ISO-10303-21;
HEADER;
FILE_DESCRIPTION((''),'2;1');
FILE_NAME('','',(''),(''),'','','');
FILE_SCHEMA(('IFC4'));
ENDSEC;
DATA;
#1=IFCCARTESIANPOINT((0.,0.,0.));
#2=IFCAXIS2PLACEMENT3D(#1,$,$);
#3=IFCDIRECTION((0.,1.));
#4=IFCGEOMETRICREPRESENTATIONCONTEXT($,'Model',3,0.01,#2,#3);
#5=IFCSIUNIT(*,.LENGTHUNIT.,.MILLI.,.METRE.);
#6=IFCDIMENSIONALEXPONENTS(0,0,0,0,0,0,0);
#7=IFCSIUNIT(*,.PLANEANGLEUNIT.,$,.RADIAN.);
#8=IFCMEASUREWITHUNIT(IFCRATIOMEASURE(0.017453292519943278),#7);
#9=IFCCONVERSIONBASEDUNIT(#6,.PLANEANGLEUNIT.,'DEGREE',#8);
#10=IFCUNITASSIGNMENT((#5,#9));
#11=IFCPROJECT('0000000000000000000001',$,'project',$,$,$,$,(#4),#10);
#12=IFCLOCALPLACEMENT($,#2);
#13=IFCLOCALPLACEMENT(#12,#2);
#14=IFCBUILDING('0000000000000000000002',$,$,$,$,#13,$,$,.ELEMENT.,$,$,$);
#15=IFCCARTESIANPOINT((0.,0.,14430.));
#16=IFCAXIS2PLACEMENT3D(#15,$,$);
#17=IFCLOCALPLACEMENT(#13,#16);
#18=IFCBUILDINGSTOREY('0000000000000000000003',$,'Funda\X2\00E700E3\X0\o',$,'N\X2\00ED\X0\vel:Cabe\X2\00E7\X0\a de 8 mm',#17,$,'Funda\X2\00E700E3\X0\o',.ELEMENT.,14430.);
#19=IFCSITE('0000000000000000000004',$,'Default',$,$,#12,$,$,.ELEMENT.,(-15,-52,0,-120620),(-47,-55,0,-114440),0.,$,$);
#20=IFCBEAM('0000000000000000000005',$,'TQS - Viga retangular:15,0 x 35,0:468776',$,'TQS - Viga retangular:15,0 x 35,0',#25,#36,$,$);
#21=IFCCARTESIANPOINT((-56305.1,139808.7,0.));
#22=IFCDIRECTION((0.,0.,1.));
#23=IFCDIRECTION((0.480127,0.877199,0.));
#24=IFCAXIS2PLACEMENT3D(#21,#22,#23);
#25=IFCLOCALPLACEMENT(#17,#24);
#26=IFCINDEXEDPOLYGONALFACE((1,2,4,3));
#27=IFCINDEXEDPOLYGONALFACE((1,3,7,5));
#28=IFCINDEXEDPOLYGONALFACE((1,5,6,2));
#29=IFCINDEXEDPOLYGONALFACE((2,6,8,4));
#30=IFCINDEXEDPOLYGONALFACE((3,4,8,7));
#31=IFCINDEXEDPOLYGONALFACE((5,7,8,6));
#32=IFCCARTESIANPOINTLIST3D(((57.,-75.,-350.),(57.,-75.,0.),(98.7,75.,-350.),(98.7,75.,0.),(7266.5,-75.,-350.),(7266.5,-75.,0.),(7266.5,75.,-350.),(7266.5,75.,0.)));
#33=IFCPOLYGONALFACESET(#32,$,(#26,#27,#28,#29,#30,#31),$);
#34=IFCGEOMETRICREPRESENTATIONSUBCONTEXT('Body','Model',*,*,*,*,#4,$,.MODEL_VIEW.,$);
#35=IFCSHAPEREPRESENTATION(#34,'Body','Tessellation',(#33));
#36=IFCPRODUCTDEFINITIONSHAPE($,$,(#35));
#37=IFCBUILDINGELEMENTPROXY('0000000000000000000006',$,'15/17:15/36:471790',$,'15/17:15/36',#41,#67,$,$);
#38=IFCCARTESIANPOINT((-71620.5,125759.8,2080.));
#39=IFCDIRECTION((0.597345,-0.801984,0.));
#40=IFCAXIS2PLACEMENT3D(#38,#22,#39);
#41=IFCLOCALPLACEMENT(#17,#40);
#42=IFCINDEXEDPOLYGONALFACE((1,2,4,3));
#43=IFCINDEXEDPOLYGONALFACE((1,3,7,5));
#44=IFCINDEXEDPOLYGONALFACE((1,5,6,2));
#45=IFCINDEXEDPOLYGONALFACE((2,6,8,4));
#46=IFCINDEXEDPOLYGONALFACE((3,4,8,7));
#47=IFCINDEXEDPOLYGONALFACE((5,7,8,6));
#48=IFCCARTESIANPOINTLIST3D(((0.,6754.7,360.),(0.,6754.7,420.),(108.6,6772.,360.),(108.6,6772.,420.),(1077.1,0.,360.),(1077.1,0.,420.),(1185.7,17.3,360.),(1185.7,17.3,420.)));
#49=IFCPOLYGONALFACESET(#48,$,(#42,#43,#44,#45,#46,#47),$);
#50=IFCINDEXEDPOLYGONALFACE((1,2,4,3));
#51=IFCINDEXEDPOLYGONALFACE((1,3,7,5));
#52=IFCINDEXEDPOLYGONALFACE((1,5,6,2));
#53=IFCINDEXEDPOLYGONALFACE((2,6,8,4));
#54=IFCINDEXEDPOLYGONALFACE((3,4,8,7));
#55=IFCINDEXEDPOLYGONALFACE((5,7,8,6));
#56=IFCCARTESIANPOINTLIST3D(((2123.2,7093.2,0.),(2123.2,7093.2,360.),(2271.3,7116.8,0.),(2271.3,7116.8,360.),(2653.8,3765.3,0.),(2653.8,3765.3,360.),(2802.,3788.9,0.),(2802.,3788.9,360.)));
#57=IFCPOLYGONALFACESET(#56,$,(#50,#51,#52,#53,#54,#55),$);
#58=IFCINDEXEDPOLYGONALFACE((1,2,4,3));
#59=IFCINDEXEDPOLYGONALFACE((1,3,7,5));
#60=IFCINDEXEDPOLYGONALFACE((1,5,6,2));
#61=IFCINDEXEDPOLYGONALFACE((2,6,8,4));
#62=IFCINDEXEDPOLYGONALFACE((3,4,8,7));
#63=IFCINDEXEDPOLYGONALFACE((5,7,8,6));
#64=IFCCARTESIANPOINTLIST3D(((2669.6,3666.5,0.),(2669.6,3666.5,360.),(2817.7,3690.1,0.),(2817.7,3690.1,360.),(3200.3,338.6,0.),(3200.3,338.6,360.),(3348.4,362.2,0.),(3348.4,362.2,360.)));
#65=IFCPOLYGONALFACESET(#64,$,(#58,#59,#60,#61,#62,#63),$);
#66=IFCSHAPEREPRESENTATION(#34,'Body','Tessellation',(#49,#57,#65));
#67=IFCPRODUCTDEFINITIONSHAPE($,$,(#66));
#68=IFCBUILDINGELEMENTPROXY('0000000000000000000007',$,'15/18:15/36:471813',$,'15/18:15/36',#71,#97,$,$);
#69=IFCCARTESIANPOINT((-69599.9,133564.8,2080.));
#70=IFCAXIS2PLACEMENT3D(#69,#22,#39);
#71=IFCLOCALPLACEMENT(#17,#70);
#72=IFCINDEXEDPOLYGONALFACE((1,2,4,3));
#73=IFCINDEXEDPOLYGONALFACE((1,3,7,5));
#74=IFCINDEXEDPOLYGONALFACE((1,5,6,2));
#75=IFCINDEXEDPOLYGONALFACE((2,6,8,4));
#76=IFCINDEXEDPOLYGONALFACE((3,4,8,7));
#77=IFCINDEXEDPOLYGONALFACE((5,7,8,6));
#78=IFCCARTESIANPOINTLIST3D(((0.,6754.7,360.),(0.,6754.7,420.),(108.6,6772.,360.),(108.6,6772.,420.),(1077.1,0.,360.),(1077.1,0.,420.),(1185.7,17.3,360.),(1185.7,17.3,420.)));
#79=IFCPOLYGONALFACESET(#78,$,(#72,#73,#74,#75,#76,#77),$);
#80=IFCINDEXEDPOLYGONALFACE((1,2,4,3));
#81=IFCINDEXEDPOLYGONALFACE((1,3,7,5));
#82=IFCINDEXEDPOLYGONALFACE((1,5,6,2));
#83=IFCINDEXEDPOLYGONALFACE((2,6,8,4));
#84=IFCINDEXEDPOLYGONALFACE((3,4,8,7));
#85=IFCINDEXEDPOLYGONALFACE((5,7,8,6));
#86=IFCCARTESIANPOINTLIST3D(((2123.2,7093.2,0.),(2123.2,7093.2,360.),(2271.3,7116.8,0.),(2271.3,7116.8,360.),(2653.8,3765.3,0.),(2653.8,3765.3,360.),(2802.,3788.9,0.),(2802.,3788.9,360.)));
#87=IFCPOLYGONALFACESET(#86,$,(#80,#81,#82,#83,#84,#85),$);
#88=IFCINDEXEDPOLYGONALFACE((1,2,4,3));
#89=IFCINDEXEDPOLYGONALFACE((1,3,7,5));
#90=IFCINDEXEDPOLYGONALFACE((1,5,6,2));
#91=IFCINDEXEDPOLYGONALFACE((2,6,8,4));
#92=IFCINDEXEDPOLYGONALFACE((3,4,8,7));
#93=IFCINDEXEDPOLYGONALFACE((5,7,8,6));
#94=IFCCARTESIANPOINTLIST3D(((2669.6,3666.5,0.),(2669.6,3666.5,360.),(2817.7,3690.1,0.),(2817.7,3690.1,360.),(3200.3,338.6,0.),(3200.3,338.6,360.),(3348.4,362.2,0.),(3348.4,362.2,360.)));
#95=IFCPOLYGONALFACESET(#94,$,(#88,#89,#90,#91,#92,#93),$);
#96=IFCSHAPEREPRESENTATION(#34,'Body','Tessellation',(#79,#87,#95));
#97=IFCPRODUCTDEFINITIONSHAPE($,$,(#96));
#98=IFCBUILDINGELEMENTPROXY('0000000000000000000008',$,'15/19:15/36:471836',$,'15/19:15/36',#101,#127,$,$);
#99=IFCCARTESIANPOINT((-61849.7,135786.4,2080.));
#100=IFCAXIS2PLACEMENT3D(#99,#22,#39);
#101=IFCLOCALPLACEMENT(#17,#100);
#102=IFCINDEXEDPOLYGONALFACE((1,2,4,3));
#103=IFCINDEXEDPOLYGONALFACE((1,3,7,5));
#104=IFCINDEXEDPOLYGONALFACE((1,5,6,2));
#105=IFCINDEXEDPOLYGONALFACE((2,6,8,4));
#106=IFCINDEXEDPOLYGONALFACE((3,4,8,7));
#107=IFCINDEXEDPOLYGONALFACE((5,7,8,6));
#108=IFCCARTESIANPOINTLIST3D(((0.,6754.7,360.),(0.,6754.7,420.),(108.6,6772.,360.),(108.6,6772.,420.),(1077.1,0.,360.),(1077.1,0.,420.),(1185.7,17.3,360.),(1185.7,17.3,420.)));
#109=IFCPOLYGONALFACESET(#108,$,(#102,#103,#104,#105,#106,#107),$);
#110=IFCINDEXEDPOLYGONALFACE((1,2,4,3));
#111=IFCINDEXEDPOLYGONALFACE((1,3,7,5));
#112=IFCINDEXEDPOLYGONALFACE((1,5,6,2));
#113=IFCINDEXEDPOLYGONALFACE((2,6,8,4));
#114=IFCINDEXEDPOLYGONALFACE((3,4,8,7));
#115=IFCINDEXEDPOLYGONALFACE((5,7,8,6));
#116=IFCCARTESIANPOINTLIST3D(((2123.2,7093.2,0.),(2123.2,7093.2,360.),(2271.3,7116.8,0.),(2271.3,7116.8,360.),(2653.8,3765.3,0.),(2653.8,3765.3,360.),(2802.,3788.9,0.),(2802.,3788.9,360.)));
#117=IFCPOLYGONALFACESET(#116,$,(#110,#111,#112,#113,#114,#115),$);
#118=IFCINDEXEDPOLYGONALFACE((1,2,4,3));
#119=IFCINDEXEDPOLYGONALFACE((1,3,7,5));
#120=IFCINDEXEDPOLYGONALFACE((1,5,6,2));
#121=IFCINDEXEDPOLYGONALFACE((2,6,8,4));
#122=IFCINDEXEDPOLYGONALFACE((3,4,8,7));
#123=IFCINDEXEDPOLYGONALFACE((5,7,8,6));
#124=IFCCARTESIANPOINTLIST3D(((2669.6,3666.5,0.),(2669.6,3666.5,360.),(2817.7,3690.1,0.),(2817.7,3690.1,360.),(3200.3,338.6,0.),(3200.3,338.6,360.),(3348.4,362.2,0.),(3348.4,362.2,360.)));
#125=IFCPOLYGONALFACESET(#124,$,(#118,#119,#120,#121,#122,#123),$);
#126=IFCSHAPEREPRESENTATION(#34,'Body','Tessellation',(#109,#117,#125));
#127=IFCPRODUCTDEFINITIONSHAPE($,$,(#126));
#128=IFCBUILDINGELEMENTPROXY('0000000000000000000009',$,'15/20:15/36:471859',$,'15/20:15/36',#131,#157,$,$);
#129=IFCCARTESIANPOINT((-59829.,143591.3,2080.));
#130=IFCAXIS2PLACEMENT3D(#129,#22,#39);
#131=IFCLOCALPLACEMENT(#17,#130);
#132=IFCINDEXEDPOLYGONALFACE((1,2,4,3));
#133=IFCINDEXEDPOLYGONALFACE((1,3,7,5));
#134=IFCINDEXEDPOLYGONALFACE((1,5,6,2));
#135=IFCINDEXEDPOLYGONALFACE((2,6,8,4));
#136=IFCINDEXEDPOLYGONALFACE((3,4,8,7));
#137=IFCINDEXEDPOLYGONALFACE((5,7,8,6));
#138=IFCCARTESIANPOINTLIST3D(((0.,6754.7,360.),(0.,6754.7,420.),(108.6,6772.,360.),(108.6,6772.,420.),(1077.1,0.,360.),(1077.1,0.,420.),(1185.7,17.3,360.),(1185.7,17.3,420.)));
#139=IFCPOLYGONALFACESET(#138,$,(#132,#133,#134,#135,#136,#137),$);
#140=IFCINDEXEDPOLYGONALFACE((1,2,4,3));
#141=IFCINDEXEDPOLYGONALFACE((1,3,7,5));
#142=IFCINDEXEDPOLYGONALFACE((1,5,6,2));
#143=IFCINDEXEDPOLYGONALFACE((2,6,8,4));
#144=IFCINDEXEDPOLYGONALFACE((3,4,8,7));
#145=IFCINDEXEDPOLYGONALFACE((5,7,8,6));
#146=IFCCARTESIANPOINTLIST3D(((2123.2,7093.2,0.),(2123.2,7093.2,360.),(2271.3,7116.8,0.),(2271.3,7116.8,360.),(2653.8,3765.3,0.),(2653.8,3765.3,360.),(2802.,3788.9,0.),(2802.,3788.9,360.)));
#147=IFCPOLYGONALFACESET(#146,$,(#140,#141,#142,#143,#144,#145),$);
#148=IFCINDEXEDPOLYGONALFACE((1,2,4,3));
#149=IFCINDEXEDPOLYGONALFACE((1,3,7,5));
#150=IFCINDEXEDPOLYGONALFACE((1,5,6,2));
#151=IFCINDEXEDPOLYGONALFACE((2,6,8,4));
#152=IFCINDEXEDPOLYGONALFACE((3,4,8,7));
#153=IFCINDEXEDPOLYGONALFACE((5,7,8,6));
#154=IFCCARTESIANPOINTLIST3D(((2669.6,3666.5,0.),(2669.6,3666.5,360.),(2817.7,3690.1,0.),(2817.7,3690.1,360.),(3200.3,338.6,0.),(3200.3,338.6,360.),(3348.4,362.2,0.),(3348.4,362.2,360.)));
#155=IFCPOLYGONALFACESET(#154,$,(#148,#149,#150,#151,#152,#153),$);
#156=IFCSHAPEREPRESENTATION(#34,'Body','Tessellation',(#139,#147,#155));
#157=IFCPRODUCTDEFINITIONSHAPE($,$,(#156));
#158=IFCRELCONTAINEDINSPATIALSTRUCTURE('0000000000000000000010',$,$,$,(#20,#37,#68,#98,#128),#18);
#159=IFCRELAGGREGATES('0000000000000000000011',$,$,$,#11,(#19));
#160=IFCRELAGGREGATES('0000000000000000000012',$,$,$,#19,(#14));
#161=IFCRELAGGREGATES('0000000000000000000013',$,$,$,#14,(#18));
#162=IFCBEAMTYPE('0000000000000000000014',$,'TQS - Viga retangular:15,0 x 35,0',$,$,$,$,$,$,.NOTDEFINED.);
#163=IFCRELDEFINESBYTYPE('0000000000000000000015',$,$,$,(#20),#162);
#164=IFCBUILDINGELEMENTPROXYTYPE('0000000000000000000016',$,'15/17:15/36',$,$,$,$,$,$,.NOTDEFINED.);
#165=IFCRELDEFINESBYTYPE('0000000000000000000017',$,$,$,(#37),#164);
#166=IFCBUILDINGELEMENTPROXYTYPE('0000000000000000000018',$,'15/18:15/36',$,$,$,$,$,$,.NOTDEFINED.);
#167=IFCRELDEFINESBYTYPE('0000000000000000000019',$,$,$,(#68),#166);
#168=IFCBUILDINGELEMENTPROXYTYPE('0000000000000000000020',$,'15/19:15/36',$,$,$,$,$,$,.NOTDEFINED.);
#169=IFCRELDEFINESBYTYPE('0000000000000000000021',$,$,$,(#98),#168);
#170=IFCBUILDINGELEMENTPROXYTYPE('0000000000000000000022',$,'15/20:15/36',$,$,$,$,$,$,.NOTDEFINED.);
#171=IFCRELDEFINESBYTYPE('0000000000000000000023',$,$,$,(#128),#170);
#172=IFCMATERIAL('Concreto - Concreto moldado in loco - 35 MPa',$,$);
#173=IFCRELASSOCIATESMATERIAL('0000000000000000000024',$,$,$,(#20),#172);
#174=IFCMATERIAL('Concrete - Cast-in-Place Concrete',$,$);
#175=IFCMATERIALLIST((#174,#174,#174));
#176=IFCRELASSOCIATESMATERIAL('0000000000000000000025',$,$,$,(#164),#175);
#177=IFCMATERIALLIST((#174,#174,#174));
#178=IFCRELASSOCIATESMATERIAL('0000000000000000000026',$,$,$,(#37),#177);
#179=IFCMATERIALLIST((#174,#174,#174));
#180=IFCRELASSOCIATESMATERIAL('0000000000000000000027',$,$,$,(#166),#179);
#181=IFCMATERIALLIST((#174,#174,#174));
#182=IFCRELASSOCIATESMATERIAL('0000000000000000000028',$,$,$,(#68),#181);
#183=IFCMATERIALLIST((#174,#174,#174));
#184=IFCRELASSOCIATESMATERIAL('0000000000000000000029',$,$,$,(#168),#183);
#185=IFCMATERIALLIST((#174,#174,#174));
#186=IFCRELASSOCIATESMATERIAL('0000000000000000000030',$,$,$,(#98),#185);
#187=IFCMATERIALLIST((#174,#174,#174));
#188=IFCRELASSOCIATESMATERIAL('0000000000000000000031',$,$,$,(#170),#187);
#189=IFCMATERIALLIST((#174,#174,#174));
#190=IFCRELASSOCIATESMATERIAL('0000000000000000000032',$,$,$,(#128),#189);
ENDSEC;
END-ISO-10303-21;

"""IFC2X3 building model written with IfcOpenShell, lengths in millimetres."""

from ifc_helpers import new_model, entity, si_unit, converted_unit, direction, frame, frame_2d, origin, origin_2d_with_axis, place, context, subcontext, project, spatial, rectangle, extrude, clip, halfspace, source, transform, mapped, material, material_list, type_object, type_shapes, element, save


model = new_model("IFC2X3")

# Units and contexts
model_context = context("Model", 3, precision=0.01, world=origin(), true_north=direction((0.0, 1.0)))
body_context = subcontext(model_context, "Body", "Model", "MODEL_VIEW")
ifc_project = project(units=[si_unit("LENGTHUNIT", "METRE", prefix="MILLI"), converted_unit("PLANEANGLEUNIT", "DEGREE", entity("IfcRatioMeasure", 0.017453292519943278), si_unit("PLANEANGLEUNIT", "RADIAN"), dimensions=[0, 0, 0, 0, 0, 0, 0])], contexts=[model_context])

# Site, building, storey
site_placement = place(None, origin())
site = spatial("IfcSite", under=ifc_project, at=site_placement, Name="Default", CompositionType="ELEMENT", RefLatitude=(-15, -52, 0, -120620), RefLongitude=(-47, -55, 0, -114440), RefElevation=0.0)
building_placement = place(site_placement, origin())
building = spatial("IfcBuilding", under=site, at=building_placement, CompositionType="ELEMENT")
storey_placement = place(building_placement, frame((0.0, 0.0, 14430.0)))
storey = spatial("IfcBuildingStorey", under=building, at=storey_placement, Name="Fundação", ObjectType="Nível:Cabeça de 8 mm", LongName="Fundação", CompositionType="ELEMENT", Elevation=14430.0)

# Beam
ifc_material_1 = material(Name="Concreto - Concreto moldado in loco - 35 MPa")
beam_type = type_object("IfcBeamType", Name="TQS - Viga retangular:15,0 x 35,0", PredefinedType="NOTDEFINED")
beam_1_placement = place(storey_placement, frame((-56305.1, 139808.7, 0.0), z_axis=(0.0, 0.0, 1.0), x_axis=(0.480127, 0.877199, 0.0)))
element("IfcBeam", 1, at=beam_1_placement, inside=storey, type_object=beam_type, material=ifc_material_1, Name="TQS - Viga retangular:15,0 x 35,0:468776", ObjectType="TQS - Viga retangular:15,0 x 35,0", context=body_context, shape_type="SweptSolid", body=[
    clip(extrude(rectangle(XDim=350.0, YDim=150.0, at=frame_2d((0.0, 0.0), x_axis=(1.0, 0.0))), frame((57.0, 0.0, -175.0), z_axis=(1.0, 0.0, 0.0), x_axis=(0.0, 0.0, -1.0)), (0.0, 0.0, 1.0), 7209.6), halfspace(frame((1149.0, 3845.0, -175.0), z_axis=(-0.96332, 0.268354, 0.0), x_axis=(0.0, 0.0, -1.0)), False)),
])

# Building element proxies
ifc_material_2 = material(Name="Concrete - Cast-in-Place Concrete")
ifc_material_list_1 = material_list([ifc_material_2, ifc_material_2, ifc_material_2])
ifc_material_list_2 = material_list([ifc_material_2, ifc_material_2, ifc_material_2])
building_element_proxy_type_1 = type_object("IfcBuildingElementProxyType", Name="15/17:15/36", PredefinedType="NOTDEFINED", material=ifc_material_list_2)
shared_shape_1 = source(origin(), body_context, "Body", "SweptSolid", [
    extrude(rectangle(XDim=110.0, YDim=6840.0, at=frame_2d((0.0, 0.0), x_axis=(1.0, 0.0))), frame((592.9, 3386.0, 360.0), z_axis=(0.0, 0.0, 1.0), x_axis=(-0.987524, -0.157469, 0.0)), (0.0, 0.0, 1.0), 60.0),
    extrude(rectangle(XDim=3370.0, YDim=150.0, at=origin_2d_with_axis()), frame((2462.6, 5441.1, 0.0), z_axis=(0.0, 0.0, 1.0), x_axis=(0.157469, -0.987524, 0.0)), (0.0, 0.0, 1.0), 360.0),
    extrude(rectangle(XDim=3370.0, YDim=150.0, at=frame_2d((0.0, 0.0), x_axis=(1.0, 0.0))), frame((3009.0, 2014.3, 0.0), z_axis=(0.0, 0.0, 1.0), x_axis=(0.157469, -0.987524, 0.0)), (0.0, 0.0, 1.0), 360.0),
])
type_shapes(building_element_proxy_type_1, [shared_shape_1])
proxy_1_placement = place(storey_placement, frame((-71620.5, 125759.8, 2080.0), z_axis=(0.0, 0.0, 1.0), x_axis=(0.597345, -0.801984, 0.0)))
element("IfcBuildingElementProxy", 2, at=proxy_1_placement, inside=storey, type_object=building_element_proxy_type_1, material=ifc_material_list_1, Name="15/17:15/36:471790", ObjectType="15/17:15/36", context=body_context, shape_type="MappedRepresentation", body=[
    mapped(shared_shape_1, transform((0.0, 0.0, 0.0), scale=1.0)),
])
ifc_material_list_3 = material_list([ifc_material_2, ifc_material_2, ifc_material_2])
ifc_material_list_4 = material_list([ifc_material_2, ifc_material_2, ifc_material_2])
building_element_proxy_type_2 = type_object("IfcBuildingElementProxyType", Name="15/18:15/36", PredefinedType="NOTDEFINED", material=ifc_material_list_4)
shared_shape_2 = source(origin(), body_context, "Body", "SweptSolid", [
    extrude(rectangle(XDim=110.0, YDim=6840.0, at=frame_2d((0.0, 0.0), x_axis=(1.0, 0.0))), frame((592.9, 3386.0, 360.0), z_axis=(0.0, 0.0, 1.0), x_axis=(-0.987524, -0.157469, 0.0)), (0.0, 0.0, 1.0), 60.0),
    extrude(rectangle(XDim=3370.0, YDim=150.0, at=origin_2d_with_axis()), frame((2462.6, 5441.1, 0.0), z_axis=(0.0, 0.0, 1.0), x_axis=(0.157469, -0.987524, 0.0)), (0.0, 0.0, 1.0), 360.0),
    extrude(rectangle(XDim=3370.0, YDim=150.0, at=frame_2d((0.0, 0.0), x_axis=(1.0, 0.0))), frame((3009.0, 2014.3, 0.0), z_axis=(0.0, 0.0, 1.0), x_axis=(0.157469, -0.987524, 0.0)), (0.0, 0.0, 1.0), 360.0),
])
type_shapes(building_element_proxy_type_2, [shared_shape_2])
proxy_2_placement = place(storey_placement, frame((-69599.9, 133564.8, 2080.0), z_axis=(0.0, 0.0, 1.0), x_axis=(0.597345, -0.801984, 0.0)))
element("IfcBuildingElementProxy", 3, at=proxy_2_placement, inside=storey, type_object=building_element_proxy_type_2, material=ifc_material_list_3, Name="15/18:15/36:471813", ObjectType="15/18:15/36", context=body_context, shape_type="MappedRepresentation", body=[
    mapped(shared_shape_2, transform((0.0, 0.0, 0.0), scale=1.0)),
])
ifc_material_list_5 = material_list([ifc_material_2, ifc_material_2, ifc_material_2])
ifc_material_list_6 = material_list([ifc_material_2, ifc_material_2, ifc_material_2])
building_element_proxy_type_3 = type_object("IfcBuildingElementProxyType", Name="15/19:15/36", PredefinedType="NOTDEFINED", material=ifc_material_list_6)
shared_shape_3 = source(origin(), body_context, "Body", "SweptSolid", [
    extrude(rectangle(XDim=110.0, YDim=6840.0, at=frame_2d((0.0, 0.0), x_axis=(1.0, 0.0))), frame((592.9, 3386.0, 360.0), z_axis=(0.0, 0.0, 1.0), x_axis=(-0.987524, -0.157469, 0.0)), (0.0, 0.0, 1.0), 60.0),
    extrude(rectangle(XDim=3370.0, YDim=150.0, at=origin_2d_with_axis()), frame((2462.6, 5441.1, 0.0), z_axis=(0.0, 0.0, 1.0), x_axis=(0.157469, -0.987524, 0.0)), (0.0, 0.0, 1.0), 360.0),
    extrude(rectangle(XDim=3370.0, YDim=150.0, at=frame_2d((0.0, 0.0), x_axis=(1.0, 0.0))), frame((3009.0, 2014.3, 0.0), z_axis=(0.0, 0.0, 1.0), x_axis=(0.157469, -0.987524, 0.0)), (0.0, 0.0, 1.0), 360.0),
])
type_shapes(building_element_proxy_type_3, [shared_shape_3])
proxy_3_placement = place(storey_placement, frame((-61849.7, 135786.4, 2080.0), z_axis=(0.0, 0.0, 1.0), x_axis=(0.597345, -0.801984, 0.0)))
element("IfcBuildingElementProxy", 4, at=proxy_3_placement, inside=storey, type_object=building_element_proxy_type_3, material=ifc_material_list_5, Name="15/19:15/36:471836", ObjectType="15/19:15/36", context=body_context, shape_type="MappedRepresentation", body=[
    mapped(shared_shape_3, transform((0.0, 0.0, 0.0), scale=1.0)),
])
ifc_material_list_7 = material_list([ifc_material_2, ifc_material_2, ifc_material_2])
ifc_material_list_8 = material_list([ifc_material_2, ifc_material_2, ifc_material_2])
building_element_proxy_type_4 = type_object("IfcBuildingElementProxyType", Name="15/20:15/36", PredefinedType="NOTDEFINED", material=ifc_material_list_8)
shared_shape_4 = source(origin(), body_context, "Body", "SweptSolid", [
    extrude(rectangle(XDim=110.0, YDim=6840.0, at=frame_2d((0.0, 0.0), x_axis=(1.0, 0.0))), frame((592.9, 3386.0, 360.0), z_axis=(0.0, 0.0, 1.0), x_axis=(-0.987524, -0.157469, 0.0)), (0.0, 0.0, 1.0), 60.0),
    extrude(rectangle(XDim=3370.0, YDim=150.0, at=origin_2d_with_axis()), frame((2462.6, 5441.1, 0.0), z_axis=(0.0, 0.0, 1.0), x_axis=(0.157469, -0.987524, 0.0)), (0.0, 0.0, 1.0), 360.0),
    extrude(rectangle(XDim=3370.0, YDim=150.0, at=frame_2d((0.0, 0.0), x_axis=(1.0, 0.0))), frame((3009.0, 2014.3, 0.0), z_axis=(0.0, 0.0, 1.0), x_axis=(0.157469, -0.987524, 0.0)), (0.0, 0.0, 1.0), 360.0),
])
type_shapes(building_element_proxy_type_4, [shared_shape_4])
proxy_4_placement = place(storey_placement, frame((-59829.0, 143591.3, 2080.0), z_axis=(0.0, 0.0, 1.0), x_axis=(0.597345, -0.801984, 0.0)))
element("IfcBuildingElementProxy", 5, at=proxy_4_placement, inside=storey, type_object=building_element_proxy_type_4, material=ifc_material_list_7, Name="15/20:15/36:471859", ObjectType="15/20:15/36", context=body_context, shape_type="MappedRepresentation", body=[
    mapped(shared_shape_4, transform((0.0, 0.0, 0.0), scale=1.0)),
])

save(model, "model.ifc")
